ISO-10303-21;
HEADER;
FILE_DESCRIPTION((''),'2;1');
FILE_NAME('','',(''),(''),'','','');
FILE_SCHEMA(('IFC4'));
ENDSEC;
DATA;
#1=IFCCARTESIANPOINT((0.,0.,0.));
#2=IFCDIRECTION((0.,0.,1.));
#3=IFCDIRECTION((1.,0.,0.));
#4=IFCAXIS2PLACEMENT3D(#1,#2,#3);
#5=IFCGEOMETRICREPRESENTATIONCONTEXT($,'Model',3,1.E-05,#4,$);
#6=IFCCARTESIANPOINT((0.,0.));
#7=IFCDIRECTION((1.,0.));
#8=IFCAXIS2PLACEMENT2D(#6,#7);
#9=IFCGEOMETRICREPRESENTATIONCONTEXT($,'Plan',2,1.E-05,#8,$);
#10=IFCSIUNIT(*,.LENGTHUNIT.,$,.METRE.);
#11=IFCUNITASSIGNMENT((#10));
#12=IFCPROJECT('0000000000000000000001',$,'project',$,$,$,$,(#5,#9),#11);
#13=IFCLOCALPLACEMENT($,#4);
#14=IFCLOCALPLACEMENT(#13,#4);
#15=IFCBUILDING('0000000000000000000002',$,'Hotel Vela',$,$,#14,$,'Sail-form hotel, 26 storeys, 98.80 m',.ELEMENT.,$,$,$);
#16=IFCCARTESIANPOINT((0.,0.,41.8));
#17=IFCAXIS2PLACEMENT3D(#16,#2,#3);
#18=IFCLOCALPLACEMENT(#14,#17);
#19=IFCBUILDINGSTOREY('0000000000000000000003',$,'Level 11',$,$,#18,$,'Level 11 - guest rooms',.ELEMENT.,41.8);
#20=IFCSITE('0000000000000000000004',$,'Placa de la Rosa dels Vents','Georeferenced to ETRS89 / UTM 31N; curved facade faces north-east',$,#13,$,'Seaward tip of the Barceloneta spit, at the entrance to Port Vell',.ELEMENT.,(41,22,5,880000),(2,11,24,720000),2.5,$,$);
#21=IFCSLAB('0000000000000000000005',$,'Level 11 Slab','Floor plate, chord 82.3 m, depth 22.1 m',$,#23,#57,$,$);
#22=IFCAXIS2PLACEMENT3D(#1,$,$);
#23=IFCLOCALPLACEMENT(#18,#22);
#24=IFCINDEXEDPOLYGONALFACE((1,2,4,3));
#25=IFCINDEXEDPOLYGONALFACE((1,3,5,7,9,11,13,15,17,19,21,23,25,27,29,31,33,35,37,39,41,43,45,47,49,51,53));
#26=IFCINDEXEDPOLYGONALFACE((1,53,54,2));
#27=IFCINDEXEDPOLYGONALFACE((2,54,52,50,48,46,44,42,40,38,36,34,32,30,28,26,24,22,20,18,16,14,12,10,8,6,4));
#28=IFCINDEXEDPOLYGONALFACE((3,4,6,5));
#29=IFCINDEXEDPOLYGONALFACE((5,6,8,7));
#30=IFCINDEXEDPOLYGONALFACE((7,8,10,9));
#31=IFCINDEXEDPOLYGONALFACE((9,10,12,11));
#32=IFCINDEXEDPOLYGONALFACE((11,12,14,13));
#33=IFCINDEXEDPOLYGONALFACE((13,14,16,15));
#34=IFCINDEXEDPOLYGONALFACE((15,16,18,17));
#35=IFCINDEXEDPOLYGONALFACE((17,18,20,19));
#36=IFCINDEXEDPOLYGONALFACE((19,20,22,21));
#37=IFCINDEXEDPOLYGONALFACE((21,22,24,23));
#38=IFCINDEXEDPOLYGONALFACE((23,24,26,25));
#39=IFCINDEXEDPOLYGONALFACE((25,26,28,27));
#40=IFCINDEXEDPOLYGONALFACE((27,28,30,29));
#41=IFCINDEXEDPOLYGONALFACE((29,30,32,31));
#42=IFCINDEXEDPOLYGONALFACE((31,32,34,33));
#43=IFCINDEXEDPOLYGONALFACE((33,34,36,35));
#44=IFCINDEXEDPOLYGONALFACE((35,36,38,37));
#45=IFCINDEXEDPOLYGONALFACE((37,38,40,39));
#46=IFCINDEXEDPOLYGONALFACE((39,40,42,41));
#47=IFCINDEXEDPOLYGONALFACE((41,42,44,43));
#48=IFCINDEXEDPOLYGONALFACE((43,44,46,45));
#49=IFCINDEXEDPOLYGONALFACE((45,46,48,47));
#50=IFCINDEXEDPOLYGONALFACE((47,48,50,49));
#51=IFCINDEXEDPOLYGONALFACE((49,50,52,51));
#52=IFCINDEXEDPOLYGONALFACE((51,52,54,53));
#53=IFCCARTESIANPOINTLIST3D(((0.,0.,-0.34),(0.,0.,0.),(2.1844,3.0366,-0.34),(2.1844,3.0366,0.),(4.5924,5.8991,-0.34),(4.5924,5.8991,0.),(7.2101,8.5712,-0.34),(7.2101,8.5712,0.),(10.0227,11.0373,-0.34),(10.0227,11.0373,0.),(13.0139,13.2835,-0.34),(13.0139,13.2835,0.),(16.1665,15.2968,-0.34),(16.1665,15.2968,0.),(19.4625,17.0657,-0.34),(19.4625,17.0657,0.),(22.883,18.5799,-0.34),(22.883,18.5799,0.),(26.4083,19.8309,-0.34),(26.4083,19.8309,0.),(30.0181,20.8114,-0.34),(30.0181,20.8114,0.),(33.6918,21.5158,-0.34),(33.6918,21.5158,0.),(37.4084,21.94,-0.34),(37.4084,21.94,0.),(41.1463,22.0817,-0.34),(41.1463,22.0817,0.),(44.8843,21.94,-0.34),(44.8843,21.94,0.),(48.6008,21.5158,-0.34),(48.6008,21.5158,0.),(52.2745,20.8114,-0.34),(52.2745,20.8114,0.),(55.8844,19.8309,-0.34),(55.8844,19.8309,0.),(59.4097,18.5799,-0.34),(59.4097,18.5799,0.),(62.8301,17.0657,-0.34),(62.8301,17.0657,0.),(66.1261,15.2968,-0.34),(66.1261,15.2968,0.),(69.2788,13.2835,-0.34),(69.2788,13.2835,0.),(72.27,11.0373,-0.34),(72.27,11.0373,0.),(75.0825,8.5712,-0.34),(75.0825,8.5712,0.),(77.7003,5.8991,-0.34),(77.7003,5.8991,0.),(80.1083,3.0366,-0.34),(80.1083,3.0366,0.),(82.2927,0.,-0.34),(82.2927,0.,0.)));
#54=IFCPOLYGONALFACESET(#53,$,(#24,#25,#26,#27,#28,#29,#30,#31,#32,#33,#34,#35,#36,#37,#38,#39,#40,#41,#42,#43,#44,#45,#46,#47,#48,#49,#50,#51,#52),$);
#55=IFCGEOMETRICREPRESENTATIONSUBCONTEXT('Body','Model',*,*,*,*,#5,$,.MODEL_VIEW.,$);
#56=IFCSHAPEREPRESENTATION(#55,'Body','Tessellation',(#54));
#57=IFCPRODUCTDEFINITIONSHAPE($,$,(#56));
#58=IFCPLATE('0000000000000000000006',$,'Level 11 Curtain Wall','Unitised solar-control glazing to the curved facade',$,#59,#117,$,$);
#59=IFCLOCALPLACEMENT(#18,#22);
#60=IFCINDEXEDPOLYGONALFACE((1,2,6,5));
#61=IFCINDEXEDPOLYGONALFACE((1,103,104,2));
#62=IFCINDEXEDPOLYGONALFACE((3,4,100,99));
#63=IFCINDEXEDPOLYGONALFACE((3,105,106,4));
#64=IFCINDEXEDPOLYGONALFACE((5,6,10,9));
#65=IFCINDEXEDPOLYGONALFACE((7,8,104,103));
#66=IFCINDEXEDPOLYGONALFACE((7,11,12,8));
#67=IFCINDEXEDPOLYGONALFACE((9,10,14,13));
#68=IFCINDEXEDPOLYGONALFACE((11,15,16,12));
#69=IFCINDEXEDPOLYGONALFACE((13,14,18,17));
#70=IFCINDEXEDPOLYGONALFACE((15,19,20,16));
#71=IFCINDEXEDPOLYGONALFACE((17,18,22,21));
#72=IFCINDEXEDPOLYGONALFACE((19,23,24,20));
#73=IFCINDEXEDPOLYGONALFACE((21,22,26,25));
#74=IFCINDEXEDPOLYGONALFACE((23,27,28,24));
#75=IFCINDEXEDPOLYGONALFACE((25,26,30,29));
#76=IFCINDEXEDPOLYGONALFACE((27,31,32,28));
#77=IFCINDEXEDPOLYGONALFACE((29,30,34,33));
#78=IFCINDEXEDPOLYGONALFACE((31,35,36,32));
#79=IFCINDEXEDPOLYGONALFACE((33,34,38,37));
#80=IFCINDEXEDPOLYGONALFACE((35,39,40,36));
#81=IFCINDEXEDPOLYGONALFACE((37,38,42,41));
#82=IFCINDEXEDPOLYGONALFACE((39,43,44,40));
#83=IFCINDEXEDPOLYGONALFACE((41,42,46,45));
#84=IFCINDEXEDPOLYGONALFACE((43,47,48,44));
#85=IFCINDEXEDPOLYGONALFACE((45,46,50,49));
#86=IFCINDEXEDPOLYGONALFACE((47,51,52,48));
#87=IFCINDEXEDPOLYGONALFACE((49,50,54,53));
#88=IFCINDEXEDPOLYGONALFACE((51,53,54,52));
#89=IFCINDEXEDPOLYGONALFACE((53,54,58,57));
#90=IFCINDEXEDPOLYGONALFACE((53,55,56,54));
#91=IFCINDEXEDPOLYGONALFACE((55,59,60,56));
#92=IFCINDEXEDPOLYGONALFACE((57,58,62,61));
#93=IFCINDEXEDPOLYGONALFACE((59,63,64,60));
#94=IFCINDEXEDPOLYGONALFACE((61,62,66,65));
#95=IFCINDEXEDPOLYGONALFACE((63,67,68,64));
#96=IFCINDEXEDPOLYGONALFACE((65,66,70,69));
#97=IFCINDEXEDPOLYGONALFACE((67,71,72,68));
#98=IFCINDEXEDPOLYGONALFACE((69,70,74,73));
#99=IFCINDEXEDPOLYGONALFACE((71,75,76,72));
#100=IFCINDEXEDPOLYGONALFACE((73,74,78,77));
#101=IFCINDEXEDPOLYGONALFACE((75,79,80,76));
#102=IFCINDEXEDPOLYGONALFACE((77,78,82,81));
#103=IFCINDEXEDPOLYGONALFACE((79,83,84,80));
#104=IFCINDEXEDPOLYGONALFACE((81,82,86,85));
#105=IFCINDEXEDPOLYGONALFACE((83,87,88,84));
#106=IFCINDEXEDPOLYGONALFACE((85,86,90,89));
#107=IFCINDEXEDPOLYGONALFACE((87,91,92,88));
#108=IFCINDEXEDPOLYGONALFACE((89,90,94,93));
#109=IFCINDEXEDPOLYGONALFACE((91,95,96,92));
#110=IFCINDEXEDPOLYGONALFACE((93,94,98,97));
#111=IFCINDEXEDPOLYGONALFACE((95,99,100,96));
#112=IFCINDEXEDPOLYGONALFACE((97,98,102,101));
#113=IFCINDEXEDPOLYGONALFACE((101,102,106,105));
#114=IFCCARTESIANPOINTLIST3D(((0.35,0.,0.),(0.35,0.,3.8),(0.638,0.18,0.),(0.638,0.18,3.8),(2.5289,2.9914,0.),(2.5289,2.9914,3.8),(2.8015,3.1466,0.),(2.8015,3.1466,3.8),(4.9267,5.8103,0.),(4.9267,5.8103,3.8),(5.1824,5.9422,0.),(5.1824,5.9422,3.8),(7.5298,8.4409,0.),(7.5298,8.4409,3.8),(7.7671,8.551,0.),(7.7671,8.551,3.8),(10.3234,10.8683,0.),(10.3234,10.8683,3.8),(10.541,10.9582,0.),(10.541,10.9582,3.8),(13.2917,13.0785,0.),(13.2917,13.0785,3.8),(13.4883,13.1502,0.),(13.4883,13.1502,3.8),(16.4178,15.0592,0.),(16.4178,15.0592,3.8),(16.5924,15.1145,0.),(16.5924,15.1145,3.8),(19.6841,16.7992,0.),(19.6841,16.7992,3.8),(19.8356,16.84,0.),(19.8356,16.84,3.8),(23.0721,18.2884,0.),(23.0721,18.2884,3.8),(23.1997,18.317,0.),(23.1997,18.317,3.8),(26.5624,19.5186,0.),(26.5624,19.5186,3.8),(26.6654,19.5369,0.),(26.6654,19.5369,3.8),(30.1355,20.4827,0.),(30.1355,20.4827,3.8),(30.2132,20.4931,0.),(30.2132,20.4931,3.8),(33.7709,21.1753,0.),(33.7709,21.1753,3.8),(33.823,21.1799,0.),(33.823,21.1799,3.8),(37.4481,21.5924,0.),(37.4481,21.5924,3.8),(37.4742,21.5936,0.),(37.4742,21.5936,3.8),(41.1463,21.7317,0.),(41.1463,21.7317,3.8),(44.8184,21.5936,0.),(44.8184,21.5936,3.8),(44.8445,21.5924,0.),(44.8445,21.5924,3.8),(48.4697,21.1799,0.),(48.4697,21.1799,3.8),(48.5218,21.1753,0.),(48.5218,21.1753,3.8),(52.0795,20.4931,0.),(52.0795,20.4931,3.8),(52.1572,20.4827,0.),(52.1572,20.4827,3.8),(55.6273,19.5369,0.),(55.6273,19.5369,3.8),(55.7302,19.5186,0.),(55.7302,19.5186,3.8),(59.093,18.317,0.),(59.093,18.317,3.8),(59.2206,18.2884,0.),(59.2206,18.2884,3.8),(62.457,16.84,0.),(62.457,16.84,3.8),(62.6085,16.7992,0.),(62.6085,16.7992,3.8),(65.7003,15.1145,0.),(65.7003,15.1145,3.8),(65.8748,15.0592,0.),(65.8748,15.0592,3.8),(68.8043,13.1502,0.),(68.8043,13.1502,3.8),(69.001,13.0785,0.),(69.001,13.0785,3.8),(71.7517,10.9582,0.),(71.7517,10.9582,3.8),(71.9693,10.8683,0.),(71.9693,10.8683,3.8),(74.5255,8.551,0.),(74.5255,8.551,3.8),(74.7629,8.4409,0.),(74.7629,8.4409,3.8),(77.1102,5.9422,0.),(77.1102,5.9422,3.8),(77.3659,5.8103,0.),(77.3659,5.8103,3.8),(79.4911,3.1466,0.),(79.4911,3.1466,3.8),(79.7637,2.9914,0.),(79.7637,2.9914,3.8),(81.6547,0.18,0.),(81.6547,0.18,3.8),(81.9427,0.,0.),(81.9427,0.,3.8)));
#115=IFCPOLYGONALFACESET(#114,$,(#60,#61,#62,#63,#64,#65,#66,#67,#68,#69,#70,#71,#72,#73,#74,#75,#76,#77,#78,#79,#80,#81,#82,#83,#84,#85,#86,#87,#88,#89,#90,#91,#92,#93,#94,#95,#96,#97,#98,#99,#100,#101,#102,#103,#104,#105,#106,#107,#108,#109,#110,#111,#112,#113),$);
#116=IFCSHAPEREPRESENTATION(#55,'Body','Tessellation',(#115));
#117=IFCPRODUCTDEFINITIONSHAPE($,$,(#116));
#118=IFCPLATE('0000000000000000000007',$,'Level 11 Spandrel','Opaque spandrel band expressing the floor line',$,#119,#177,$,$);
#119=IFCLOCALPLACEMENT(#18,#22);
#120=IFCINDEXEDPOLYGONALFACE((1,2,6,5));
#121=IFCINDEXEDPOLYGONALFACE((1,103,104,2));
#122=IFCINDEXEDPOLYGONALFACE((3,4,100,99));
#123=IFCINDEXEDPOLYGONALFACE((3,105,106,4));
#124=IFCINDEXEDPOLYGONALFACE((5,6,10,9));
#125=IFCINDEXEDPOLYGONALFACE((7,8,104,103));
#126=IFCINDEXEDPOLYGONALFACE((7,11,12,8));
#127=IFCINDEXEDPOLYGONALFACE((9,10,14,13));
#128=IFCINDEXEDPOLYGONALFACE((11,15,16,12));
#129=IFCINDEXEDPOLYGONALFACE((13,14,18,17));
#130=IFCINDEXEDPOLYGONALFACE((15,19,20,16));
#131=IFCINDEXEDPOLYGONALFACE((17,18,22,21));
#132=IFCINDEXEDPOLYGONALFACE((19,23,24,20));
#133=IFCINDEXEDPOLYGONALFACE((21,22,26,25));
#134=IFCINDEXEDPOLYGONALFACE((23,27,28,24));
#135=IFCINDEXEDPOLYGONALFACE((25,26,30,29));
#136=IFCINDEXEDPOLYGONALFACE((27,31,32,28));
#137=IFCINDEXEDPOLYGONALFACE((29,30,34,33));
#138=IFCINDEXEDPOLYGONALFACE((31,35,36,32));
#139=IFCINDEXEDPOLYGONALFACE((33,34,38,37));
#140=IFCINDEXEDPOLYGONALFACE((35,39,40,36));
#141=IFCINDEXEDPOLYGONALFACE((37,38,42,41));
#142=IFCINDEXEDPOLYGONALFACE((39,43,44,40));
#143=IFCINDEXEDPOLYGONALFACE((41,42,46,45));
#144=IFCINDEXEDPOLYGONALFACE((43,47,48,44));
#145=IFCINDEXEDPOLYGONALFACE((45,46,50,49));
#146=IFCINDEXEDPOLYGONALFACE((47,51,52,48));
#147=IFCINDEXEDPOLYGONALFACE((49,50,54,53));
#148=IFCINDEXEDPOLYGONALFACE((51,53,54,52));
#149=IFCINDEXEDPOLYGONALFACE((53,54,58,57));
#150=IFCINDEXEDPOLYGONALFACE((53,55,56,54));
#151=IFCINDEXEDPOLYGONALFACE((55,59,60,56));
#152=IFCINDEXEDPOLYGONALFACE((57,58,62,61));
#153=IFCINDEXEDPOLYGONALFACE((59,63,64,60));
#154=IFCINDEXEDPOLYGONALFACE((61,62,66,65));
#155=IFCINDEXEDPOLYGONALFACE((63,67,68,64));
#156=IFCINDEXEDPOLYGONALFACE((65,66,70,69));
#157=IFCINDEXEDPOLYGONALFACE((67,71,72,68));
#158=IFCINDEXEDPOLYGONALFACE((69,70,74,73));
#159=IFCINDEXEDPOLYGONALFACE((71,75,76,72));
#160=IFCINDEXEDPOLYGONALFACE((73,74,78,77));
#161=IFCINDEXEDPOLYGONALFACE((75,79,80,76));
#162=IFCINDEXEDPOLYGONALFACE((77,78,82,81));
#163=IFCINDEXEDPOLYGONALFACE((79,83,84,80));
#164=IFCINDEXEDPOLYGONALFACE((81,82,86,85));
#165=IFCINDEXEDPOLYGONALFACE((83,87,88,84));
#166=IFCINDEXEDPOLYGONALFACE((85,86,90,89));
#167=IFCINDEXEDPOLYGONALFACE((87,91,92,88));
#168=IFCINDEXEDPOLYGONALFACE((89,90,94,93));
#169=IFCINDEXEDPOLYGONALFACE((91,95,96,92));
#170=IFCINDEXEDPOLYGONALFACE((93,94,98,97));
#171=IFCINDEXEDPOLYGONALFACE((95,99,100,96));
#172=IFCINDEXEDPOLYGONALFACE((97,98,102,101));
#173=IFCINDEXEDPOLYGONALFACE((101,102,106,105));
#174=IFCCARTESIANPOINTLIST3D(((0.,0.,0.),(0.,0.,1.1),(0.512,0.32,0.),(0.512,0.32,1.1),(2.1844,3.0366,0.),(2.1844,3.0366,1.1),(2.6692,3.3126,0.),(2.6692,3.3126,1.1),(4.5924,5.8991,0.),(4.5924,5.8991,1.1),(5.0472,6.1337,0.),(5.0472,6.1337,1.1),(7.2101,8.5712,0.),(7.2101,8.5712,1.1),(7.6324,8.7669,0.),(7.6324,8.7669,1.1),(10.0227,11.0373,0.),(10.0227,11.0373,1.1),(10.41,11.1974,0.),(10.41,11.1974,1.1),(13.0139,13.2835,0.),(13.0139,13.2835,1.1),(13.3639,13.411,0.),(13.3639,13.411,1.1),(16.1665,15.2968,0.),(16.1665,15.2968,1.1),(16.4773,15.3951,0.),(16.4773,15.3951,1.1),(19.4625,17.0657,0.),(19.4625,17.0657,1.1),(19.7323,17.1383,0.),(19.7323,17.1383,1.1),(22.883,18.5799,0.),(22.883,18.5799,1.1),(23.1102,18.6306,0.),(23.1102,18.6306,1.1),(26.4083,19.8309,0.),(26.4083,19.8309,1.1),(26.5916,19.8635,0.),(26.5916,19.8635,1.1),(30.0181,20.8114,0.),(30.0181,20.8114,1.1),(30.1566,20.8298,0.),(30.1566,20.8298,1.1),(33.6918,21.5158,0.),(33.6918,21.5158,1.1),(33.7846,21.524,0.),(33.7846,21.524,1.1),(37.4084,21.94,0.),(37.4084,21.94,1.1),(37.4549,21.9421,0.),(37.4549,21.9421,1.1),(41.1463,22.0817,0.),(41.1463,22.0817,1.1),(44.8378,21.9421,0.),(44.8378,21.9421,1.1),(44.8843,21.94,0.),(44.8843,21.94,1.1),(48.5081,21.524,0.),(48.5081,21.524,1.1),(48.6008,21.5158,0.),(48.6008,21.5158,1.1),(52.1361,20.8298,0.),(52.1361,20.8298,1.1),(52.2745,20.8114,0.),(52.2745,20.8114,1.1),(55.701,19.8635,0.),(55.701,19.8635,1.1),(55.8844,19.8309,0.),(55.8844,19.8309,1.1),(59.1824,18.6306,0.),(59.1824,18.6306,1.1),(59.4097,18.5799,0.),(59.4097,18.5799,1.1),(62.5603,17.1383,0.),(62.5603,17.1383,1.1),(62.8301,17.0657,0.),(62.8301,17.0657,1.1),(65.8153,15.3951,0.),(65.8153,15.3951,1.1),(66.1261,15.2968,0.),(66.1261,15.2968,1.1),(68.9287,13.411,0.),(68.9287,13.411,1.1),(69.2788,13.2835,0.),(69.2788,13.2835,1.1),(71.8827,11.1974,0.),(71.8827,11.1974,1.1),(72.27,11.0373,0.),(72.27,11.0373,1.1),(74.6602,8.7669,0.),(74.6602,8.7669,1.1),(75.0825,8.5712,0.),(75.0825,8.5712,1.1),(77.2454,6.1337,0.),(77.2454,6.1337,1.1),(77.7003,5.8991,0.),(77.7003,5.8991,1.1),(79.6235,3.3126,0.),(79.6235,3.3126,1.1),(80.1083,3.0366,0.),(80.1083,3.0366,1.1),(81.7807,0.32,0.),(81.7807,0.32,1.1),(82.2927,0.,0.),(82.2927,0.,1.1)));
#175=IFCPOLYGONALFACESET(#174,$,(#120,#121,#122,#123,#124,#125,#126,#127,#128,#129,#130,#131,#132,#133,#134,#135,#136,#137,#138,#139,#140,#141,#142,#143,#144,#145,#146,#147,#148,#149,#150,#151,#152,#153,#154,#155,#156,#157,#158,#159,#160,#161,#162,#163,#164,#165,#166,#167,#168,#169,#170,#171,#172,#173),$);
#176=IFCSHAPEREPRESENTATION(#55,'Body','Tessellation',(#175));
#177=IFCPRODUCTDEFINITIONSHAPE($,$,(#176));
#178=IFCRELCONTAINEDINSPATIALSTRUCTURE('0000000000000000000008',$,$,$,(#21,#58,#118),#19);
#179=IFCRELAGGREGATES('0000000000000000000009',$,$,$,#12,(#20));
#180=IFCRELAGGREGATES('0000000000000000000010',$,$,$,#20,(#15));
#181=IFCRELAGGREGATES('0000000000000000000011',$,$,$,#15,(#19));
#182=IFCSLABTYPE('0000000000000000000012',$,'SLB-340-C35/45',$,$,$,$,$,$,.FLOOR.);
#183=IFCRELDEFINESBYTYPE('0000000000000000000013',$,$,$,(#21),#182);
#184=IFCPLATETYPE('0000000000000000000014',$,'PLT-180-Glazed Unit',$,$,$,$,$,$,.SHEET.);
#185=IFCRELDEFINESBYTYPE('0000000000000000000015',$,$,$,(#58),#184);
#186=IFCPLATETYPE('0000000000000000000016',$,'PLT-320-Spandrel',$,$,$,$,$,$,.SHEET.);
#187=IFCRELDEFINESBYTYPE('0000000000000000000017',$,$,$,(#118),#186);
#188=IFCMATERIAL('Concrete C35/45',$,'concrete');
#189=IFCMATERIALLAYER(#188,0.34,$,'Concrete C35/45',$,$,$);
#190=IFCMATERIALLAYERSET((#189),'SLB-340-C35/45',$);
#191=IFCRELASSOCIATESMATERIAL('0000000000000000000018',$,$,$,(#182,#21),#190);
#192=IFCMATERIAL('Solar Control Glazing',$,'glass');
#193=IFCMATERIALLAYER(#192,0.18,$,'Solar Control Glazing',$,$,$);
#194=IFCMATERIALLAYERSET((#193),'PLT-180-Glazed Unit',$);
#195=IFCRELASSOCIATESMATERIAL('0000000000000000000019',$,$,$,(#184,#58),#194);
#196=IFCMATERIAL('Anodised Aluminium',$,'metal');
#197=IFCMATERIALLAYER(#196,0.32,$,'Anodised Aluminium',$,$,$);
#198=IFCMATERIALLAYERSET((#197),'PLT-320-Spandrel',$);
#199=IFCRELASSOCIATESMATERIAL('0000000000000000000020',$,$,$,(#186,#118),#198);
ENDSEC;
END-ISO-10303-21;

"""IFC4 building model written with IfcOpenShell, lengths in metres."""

from ifc_helpers import new_model, si_unit, frame, origin_with_axes, origin_2d_with_axis, place, context, subcontext, project, spatial, line, indexed_curve, outline, extrude, material, layer, layer_set, layer_usage, type_object, element, save


model = new_model("IFC4")

# Units and contexts
model_context = context("Model", 3, precision=1e-05, world=origin_with_axes())
plan_context = context("Plan", 2, precision=1e-05, world=origin_2d_with_axis())
body_context = subcontext(model_context, "Body", "Model", "MODEL_VIEW")
ifc_project = project(units=[si_unit("LENGTHUNIT", "METRE")], contexts=[model_context, plan_context])

# Site, building, storey
site_placement = place(None, origin_with_axes())
site = spatial("IfcSite", under=ifc_project, at=site_placement, Name="Placa de la Rosa dels Vents", Description="Georeferenced to ETRS89 / UTM 31N; curved facade faces north-east", LongName="Seaward tip of the Barceloneta spit, at the entrance to Port Vell", CompositionType="ELEMENT", RefLatitude=(41, 22, 5, 880000), RefLongitude=(2, 11, 24, 720000), RefElevation=2.5)
building_placement = place(site_placement, origin_with_axes())
building = spatial("IfcBuilding", under=site, at=building_placement, Name="Hotel Vela", LongName="Sail-form hotel, 26 storeys, 98.80 m", CompositionType="ELEMENT")
storey_placement = place(building_placement, frame((0.0, 0.0, 41.8), z_axis=(0.0, 0.0, 1.0), x_axis=(1.0, 0.0, 0.0)))
storey = spatial("IfcBuildingStorey", under=building, at=storey_placement, Name="Level 11", LongName="Level 11 - guest rooms", CompositionType="ELEMENT", Elevation=41.8)

# Slab
ifc_material_1 = material(Name="Concrete C35/45", Category="concrete")
ifc_layer_1 = layer(ifc_material_1, 0.34, Name="Concrete C35/45")
ifc_layer_set_1 = layer_set([ifc_layer_1], Name="SLB-340-C35/45")
ifc_layer_usage_1 = layer_usage(ifc_layer_set_1, "AXIS3", "POSITIVE", 0.0)
slab_type = type_object("IfcSlabType", Name="SLB-340-C35/45", PredefinedType="FLOOR", material=ifc_layer_set_1)
slab_placement = place(storey_placement, frame((0.0, 0.0, -0.34), z_axis=(0.0, 0.0, 1.0), x_axis=(1.0, 0.0, 0.0)))
element("IfcSlab", 1, at=slab_placement, inside=storey, type_object=slab_type, material=ifc_layer_usage_1, Name="Level 11 Slab", Description="Floor plate, chord 82.3 m, depth 22.1 m", context=body_context, shape_type="SweptSolid", body=[
    extrude(outline(indexed_curve([(0.0, 0.0), (82.2927, 0.0), (80.1083, 3.0366), (77.7003, 5.8991), (75.0825, 8.5712), (72.27, 11.0373), (69.2788, 13.2835), (66.1261, 15.2968), (62.8301, 17.0657), (59.4097, 18.5799), (55.8844, 19.8309), (52.2745, 20.8114), (48.6008, 21.5158), (44.8843, 21.94), (41.1463, 22.0817), (37.4084, 21.94), (33.6918, 21.5158), (30.0181, 20.8114), (26.4083, 19.8309), (22.883, 18.5799), (19.4625, 17.0657), (16.1665, 15.2968), (13.0139, 13.2835), (10.0227, 11.0373), (7.2101, 8.5712), (4.5924, 5.8991), (2.1844, 3.0366)], segments=[line(1, 2, 3, 4, 5, 6, 7, 8, 9, 10, 11, 12, 13, 14, 15, 16, 17, 18, 19, 20, 21, 22, 23, 24, 25, 26, 27, 1)])), origin_with_axes(), (0.0, 0.0, 1.0), 0.34),
])

# Plates
ifc_material_2 = material(Name="Solar Control Glazing", Category="glass")
ifc_layer_2 = layer(ifc_material_2, 0.18, Name="Solar Control Glazing")
ifc_layer_set_2 = layer_set([ifc_layer_2], Name="PLT-180-Glazed Unit")
ifc_layer_usage_2 = layer_usage(ifc_layer_set_2, "AXIS2", "POSITIVE", 0.0)
plate_type_1 = type_object("IfcPlateType", Name="PLT-180-Glazed Unit", PredefinedType="SHEET", material=ifc_layer_set_2)
plate_1_placement = place(storey_placement, frame((0.35, 0.0, 0.0), z_axis=(0.0, 0.0, 1.0), x_axis=(1.0, 0.0, 0.0)))
element("IfcPlate", 2, at=plate_1_placement, inside=storey, type_object=plate_type_1, material=ifc_layer_usage_2, Name="Level 11 Curtain Wall", Description="Unitised solar-control glazing to the curved facade", context=body_context, shape_type="SweptSolid", body=[
    extrude(outline(indexed_curve([(81.5927, 0.0), (79.4137, 2.9914), (77.0159, 5.8103), (74.4129, 8.4409), (71.6193, 10.8683), (68.651, 13.0785), (65.5248, 15.0592), (62.2585, 16.7992), (58.8706, 18.2884), (55.3802, 19.5186), (51.8072, 20.4827), (48.1718, 21.1753), (44.4945, 21.5924), (40.7963, 21.7317), (37.0981, 21.5924), (33.4209, 21.1753), (29.7855, 20.4827), (26.2124, 19.5186), (22.7221, 18.2884), (19.3341, 16.7992), (16.0678, 15.0592), (12.9417, 13.0785), (9.9734, 10.8683), (7.1798, 8.4409), (4.5767, 5.8103), (2.1789, 2.9914), (0.0, 0.0), (81.3047, 0.18), (2.4515, 3.1466), (4.8324, 5.9422), (7.4171, 8.551), (10.191, 10.9582), (13.1383, 13.1502), (16.2424, 15.1145), (19.4856, 16.84), (22.8497, 18.317), (26.3154, 19.5369), (29.8632, 20.4931), (33.473, 21.1799), (37.1242, 21.5936), (40.7963, 21.7317), (44.4684, 21.5936), (48.1197, 21.1799), (51.7295, 20.4931), (55.2773, 19.5369), (58.743, 18.317), (62.107, 16.84), (65.3503, 15.1145), (68.4543, 13.1502), (71.4017, 10.9582), (74.1755, 8.551), (76.7602, 5.9422), (79.1411, 3.1466), (0.288, 0.18)], segments=[line(1, 2, 3, 4, 5, 6, 7, 8, 9, 10, 11, 12, 13, 14, 15, 16, 17, 18, 19, 20, 21, 22, 23, 24, 25, 26, 27, 28, 29, 30, 31, 32, 33, 34, 35, 36, 37, 38, 39, 40, 41, 42, 43, 44, 45, 46, 47, 48, 49, 50, 51, 52, 53, 54, 1)])), origin_with_axes(), (0.0, 0.0, 1.0), 3.8),
])
ifc_material_3 = material(Name="Anodised Aluminium", Category="metal")
ifc_layer_3 = layer(ifc_material_3, 0.32, Name="Anodised Aluminium")
ifc_layer_set_3 = layer_set([ifc_layer_3], Name="PLT-320-Spandrel")
ifc_layer_usage_3 = layer_usage(ifc_layer_set_3, "AXIS2", "POSITIVE", 0.0)
plate_type_2 = type_object("IfcPlateType", Name="PLT-320-Spandrel", PredefinedType="SHEET", material=ifc_layer_set_3)
plate_2_placement = place(storey_placement, origin_with_axes())
element("IfcPlate", 3, at=plate_2_placement, inside=storey, type_object=plate_type_2, material=ifc_layer_usage_3, Name="Level 11 Spandrel", Description="Opaque spandrel band expressing the floor line", context=body_context, shape_type="SweptSolid", body=[
    extrude(outline(indexed_curve([(82.2927, 0.0), (80.1083, 3.0366), (77.7003, 5.8991), (75.0825, 8.5712), (72.27, 11.0373), (69.2788, 13.2835), (66.1261, 15.2968), (62.8301, 17.0657), (59.4097, 18.5799), (55.8844, 19.8309), (52.2745, 20.8114), (48.6008, 21.5158), (44.8843, 21.94), (41.1463, 22.0817), (37.4084, 21.94), (33.6918, 21.5158), (30.0181, 20.8114), (26.4083, 19.8309), (22.883, 18.5799), (19.4625, 17.0657), (16.1665, 15.2968), (13.0139, 13.2835), (10.0227, 11.0373), (7.2101, 8.5712), (4.5924, 5.8991), (2.1844, 3.0366), (0.0, 0.0), (81.7807, 0.32), (2.6692, 3.3126), (5.0472, 6.1337), (7.6324, 8.7669), (10.41, 11.1974), (13.3639, 13.411), (16.4773, 15.3951), (19.7323, 17.1383), (23.1102, 18.6306), (26.5916, 19.8635), (30.1566, 20.8298), (33.7846, 21.524), (37.4549, 21.9421), (41.1463, 22.0817), (44.8378, 21.9421), (48.5081, 21.524), (52.1361, 20.8298), (55.701, 19.8635), (59.1824, 18.6306), (62.5603, 17.1383), (65.8153, 15.3951), (68.9287, 13.411), (71.8827, 11.1974), (74.6602, 8.7669), (77.2454, 6.1337), (79.6235, 3.3126), (0.512, 0.32)], segments=[line(1, 2, 3, 4, 5, 6, 7, 8, 9, 10, 11, 12, 13, 14, 15, 16, 17, 18, 19, 20, 21, 22, 23, 24, 25, 26, 27, 28, 29, 30, 31, 32, 33, 34, 35, 36, 37, 38, 39, 40, 41, 42, 43, 44, 45, 46, 47, 48, 49, 50, 51, 52, 53, 54, 1)])), origin_with_axes(), (0.0, 0.0, 1.0), 1.1),
])

save(model, "model.ifc")
